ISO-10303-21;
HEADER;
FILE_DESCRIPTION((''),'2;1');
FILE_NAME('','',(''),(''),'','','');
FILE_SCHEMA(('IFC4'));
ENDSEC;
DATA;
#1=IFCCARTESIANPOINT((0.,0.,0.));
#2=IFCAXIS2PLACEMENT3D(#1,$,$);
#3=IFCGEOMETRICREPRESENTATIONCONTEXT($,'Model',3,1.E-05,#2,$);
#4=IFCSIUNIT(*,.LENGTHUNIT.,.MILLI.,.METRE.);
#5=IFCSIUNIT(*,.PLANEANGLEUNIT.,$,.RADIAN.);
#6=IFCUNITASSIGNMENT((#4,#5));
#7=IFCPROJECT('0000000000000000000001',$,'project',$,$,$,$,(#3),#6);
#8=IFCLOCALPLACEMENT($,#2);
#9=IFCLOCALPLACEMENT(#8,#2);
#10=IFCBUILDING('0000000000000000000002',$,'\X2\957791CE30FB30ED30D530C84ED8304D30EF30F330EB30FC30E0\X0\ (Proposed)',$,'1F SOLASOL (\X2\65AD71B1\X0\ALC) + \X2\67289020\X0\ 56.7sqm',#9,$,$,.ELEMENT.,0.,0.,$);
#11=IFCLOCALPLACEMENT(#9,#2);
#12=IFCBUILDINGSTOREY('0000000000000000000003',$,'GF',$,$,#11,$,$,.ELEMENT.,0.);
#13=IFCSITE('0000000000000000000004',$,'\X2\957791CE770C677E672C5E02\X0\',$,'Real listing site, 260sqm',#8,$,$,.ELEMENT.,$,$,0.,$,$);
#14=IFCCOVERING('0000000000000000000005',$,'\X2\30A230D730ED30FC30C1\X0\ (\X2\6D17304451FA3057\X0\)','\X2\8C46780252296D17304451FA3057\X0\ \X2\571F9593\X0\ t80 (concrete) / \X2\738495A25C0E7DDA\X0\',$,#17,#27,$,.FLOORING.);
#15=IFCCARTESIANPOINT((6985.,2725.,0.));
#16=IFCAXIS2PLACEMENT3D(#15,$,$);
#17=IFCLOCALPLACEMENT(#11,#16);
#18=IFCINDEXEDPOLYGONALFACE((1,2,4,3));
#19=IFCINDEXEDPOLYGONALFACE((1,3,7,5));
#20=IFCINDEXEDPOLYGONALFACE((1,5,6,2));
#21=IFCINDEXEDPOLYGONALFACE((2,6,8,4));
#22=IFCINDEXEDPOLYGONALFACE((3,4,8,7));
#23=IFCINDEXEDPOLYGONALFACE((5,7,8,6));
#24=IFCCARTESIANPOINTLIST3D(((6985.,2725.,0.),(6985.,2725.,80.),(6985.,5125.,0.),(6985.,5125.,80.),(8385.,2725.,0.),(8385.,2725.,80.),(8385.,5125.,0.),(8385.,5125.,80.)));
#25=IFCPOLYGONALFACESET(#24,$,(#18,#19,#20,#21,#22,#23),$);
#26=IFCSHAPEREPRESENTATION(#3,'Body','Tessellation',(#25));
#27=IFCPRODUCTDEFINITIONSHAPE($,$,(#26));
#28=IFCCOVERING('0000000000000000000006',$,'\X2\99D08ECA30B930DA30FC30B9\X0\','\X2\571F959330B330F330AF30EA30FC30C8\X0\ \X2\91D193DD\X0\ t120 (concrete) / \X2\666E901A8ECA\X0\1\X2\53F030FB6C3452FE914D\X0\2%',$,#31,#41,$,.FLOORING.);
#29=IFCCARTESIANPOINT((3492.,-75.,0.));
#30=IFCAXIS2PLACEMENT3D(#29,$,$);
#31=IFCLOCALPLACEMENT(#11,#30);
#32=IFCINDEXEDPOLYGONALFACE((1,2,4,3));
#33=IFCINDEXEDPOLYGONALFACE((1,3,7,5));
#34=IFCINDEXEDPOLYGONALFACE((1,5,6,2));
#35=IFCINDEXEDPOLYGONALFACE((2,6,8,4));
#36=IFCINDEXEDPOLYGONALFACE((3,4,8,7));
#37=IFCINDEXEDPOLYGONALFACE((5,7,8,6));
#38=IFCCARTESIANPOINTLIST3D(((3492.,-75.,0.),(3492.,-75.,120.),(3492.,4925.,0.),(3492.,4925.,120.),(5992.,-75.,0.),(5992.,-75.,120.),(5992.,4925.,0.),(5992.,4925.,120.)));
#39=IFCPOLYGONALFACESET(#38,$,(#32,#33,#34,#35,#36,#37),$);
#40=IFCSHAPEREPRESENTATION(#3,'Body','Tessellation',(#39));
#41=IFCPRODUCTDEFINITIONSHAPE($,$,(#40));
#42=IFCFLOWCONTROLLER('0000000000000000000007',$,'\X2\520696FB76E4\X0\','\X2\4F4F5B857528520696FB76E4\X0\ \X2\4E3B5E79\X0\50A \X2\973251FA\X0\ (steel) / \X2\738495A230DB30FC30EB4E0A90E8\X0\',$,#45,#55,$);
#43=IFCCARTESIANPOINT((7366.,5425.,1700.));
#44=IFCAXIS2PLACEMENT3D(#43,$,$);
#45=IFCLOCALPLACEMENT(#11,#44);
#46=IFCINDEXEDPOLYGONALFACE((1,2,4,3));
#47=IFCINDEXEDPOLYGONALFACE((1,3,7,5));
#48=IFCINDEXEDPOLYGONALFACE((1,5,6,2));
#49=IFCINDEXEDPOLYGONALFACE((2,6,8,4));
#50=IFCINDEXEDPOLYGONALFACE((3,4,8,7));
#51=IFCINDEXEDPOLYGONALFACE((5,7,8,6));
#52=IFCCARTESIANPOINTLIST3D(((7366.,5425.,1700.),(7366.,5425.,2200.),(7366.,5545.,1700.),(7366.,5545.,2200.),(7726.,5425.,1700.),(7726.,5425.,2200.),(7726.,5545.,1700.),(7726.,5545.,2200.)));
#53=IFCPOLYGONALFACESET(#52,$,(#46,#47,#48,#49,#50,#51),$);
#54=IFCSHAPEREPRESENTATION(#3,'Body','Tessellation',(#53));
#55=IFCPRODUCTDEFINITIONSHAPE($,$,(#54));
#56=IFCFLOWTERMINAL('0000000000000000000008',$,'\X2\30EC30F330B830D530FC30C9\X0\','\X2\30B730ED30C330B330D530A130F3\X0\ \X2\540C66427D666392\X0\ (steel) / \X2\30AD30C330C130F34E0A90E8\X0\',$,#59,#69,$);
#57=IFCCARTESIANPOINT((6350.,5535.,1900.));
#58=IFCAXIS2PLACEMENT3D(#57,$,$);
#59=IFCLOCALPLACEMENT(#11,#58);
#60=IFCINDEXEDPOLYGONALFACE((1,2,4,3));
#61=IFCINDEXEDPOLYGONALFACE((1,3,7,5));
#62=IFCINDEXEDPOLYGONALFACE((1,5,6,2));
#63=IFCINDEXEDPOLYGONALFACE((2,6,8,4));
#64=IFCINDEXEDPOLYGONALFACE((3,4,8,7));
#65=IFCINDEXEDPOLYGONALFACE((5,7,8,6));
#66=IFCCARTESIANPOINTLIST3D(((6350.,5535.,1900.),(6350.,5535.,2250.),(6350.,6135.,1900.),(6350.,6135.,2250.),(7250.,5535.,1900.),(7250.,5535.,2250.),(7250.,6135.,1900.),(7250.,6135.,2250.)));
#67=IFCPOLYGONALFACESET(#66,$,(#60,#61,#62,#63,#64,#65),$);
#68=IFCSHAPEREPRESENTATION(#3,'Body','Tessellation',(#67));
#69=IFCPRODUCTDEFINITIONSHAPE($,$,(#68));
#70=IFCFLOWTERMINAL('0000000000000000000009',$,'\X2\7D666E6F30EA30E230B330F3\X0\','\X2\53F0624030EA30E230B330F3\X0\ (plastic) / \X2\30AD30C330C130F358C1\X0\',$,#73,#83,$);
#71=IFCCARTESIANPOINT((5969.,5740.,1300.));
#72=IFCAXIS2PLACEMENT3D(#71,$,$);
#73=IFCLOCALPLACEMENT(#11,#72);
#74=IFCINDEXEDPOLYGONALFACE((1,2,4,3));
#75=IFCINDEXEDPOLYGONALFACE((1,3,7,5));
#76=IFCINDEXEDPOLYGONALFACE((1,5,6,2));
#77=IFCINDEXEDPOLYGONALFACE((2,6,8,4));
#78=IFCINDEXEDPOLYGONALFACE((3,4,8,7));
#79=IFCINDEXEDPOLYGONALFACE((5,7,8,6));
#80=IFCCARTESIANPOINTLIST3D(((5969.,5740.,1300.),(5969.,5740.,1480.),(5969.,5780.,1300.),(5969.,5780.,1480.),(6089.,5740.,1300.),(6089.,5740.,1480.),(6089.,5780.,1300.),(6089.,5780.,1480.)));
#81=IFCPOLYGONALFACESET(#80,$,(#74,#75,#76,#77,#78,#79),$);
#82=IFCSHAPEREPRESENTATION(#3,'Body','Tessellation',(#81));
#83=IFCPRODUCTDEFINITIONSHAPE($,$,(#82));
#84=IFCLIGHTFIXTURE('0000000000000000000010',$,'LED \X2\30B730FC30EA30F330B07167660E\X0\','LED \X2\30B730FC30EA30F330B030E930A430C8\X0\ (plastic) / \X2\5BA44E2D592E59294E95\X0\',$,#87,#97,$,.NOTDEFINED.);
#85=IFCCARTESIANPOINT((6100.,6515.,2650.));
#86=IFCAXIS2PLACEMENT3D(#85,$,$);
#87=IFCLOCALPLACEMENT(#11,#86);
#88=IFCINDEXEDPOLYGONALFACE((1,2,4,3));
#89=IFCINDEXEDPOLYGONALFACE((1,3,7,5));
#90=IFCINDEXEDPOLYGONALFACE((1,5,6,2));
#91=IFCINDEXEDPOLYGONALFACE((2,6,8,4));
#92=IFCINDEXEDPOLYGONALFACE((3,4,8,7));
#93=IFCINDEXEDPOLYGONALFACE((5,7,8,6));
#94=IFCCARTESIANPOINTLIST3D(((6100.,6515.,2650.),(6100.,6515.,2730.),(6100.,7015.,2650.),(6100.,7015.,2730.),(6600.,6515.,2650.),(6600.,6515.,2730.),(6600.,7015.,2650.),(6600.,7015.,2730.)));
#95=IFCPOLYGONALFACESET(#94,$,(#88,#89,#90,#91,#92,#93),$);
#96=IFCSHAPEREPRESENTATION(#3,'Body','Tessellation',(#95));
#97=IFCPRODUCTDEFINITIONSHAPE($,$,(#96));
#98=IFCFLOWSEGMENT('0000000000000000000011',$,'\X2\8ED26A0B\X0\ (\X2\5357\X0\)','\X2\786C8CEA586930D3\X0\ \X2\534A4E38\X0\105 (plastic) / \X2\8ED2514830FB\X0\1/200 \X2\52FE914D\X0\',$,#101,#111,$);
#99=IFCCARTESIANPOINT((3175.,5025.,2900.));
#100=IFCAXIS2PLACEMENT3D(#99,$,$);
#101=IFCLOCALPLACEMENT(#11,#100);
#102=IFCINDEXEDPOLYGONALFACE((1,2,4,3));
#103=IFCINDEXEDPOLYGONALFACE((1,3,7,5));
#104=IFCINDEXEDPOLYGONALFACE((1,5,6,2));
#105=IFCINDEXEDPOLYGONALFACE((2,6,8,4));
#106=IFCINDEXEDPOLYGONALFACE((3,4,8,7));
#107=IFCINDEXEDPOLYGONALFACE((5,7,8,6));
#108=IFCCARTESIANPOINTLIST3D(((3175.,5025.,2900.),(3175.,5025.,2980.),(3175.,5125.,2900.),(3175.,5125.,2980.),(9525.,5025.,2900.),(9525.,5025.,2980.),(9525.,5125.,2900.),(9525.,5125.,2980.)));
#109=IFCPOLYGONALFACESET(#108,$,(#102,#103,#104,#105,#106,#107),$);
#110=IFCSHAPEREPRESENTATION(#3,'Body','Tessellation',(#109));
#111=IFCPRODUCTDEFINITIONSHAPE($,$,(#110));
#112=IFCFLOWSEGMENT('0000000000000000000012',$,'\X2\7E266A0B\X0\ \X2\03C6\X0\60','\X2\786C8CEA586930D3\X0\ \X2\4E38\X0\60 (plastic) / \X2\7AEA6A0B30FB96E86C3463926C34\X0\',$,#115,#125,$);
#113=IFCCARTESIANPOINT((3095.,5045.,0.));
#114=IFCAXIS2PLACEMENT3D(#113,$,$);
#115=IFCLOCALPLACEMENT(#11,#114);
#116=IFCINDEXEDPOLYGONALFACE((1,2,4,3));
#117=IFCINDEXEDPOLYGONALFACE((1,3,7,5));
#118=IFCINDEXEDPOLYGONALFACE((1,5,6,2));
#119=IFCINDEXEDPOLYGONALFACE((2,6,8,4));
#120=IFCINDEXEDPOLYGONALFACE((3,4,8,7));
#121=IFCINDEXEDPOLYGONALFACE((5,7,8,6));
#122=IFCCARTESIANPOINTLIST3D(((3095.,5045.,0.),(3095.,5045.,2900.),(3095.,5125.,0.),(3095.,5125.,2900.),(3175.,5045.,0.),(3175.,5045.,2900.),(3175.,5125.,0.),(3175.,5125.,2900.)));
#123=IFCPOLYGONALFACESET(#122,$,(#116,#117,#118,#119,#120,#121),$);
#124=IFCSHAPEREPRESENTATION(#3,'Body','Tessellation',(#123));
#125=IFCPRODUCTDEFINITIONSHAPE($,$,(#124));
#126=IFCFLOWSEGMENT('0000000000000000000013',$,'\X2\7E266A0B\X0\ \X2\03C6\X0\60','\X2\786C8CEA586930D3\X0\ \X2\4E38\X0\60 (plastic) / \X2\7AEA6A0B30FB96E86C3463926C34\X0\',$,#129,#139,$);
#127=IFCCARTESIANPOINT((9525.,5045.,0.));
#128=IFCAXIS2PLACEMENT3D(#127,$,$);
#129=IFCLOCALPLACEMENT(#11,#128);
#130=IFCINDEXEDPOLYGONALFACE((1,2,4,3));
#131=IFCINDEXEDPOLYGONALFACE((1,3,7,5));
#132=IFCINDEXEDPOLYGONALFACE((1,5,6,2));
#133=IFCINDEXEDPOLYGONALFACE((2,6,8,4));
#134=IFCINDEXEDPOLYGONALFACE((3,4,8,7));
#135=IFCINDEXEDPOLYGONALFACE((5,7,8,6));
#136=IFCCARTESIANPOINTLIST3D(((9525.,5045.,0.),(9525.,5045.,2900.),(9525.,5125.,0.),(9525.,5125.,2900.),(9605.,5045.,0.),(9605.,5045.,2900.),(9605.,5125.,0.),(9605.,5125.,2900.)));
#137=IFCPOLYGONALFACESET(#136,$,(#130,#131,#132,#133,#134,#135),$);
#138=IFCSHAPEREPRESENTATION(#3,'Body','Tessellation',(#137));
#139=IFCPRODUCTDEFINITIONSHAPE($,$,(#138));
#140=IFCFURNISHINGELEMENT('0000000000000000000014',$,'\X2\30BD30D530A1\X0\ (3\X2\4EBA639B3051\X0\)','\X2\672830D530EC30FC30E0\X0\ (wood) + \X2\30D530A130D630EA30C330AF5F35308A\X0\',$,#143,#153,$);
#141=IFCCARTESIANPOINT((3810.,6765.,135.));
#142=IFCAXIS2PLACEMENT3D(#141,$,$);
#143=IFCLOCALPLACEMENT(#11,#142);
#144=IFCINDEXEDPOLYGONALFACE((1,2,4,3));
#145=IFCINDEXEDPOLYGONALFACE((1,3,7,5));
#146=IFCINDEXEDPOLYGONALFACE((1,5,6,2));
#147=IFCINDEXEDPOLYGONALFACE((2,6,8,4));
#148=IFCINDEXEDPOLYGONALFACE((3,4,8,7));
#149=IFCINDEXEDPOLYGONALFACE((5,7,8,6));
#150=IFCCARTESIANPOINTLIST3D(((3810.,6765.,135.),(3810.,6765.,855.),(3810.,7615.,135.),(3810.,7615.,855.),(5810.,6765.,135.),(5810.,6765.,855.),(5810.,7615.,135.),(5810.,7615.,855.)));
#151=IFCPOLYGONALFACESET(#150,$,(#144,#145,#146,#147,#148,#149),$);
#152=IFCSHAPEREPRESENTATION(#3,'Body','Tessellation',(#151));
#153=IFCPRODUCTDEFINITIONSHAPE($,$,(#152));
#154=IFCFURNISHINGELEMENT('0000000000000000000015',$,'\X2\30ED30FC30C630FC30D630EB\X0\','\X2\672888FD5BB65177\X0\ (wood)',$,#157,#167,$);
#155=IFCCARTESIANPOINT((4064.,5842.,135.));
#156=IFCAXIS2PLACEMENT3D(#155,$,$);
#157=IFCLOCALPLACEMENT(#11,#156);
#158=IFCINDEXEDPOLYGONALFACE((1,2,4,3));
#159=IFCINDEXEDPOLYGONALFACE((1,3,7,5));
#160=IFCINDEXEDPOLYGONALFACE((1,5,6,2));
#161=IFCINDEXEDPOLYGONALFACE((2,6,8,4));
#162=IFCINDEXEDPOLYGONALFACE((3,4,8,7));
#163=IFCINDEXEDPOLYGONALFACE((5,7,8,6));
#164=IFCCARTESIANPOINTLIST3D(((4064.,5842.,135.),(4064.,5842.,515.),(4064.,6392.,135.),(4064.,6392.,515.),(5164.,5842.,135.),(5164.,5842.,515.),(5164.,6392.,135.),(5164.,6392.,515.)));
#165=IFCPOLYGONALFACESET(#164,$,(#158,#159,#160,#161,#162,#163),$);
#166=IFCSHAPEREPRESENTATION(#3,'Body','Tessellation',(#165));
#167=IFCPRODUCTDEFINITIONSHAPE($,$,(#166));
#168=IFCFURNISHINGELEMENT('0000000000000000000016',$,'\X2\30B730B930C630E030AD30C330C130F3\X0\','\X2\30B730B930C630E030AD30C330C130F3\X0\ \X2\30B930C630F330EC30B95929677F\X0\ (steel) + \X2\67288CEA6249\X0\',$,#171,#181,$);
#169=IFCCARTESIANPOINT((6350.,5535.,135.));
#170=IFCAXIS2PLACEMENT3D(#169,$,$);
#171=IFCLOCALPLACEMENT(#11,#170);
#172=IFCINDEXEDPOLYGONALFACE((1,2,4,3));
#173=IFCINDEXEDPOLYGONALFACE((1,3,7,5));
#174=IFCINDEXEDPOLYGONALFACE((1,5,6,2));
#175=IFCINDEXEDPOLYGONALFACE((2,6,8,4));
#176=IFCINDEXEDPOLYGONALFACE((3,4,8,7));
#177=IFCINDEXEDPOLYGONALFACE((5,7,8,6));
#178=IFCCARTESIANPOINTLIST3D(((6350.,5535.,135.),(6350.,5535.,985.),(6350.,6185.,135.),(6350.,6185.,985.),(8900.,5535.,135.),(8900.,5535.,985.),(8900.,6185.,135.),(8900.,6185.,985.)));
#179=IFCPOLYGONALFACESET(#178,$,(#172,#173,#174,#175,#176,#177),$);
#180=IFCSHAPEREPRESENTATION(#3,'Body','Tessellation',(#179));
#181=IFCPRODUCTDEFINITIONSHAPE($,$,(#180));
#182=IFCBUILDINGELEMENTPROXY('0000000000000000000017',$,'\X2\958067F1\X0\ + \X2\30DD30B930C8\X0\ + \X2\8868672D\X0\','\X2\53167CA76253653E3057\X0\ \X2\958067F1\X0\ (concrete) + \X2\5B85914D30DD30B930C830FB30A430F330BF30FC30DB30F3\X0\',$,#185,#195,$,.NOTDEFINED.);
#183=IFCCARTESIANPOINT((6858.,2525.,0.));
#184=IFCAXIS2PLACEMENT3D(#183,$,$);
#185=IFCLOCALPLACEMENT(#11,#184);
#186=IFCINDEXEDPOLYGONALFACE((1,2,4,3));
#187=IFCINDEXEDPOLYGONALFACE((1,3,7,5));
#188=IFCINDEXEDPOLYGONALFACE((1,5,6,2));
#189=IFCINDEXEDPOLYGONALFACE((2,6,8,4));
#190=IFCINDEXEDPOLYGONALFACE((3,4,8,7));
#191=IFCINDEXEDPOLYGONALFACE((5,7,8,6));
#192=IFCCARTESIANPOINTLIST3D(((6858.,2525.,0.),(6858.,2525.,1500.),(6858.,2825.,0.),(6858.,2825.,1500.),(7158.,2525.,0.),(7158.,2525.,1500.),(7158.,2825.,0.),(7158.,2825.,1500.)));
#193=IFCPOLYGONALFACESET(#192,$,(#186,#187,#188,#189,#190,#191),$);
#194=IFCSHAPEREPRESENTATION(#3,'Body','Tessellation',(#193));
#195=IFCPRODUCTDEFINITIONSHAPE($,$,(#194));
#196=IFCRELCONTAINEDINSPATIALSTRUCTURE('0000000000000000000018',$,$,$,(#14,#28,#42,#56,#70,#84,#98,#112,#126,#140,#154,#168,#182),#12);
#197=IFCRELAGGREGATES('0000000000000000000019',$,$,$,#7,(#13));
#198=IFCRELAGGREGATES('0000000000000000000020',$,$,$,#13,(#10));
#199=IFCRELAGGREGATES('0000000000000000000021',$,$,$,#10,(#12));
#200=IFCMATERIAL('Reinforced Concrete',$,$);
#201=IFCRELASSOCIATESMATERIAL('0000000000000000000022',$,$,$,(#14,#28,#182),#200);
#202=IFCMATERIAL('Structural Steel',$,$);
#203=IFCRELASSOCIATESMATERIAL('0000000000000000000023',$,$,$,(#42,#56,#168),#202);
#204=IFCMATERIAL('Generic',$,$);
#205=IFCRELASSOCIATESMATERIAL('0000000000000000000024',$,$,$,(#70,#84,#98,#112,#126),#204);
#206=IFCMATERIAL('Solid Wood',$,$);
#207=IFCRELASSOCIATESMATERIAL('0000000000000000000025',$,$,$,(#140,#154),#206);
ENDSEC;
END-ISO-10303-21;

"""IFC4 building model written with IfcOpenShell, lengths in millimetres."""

from ifc_helpers import new_model, si_unit, frame, frame_2d, origin, place, context, project, spatial, rectangle, extrude, material, element, save


model = new_model("IFC4")

# Units and contexts
model_context = context("Model", 3, precision=1e-05, world=origin())
ifc_project = project(units=[si_unit("LENGTHUNIT", "METRE", prefix="MILLI"), si_unit("PLANEANGLEUNIT", "RADIAN")], contexts=[model_context])

# Site, building, storey
site_placement = place(None, origin())
site = spatial("IfcSite", under=ifc_project, at=site_placement, Name="長野県松本市", ObjectType="Real listing site, 260sqm", CompositionType="ELEMENT", RefElevation=0.0)
building_placement = place(site_placement, origin())
building = spatial("IfcBuilding", under=site, at=building_placement, Name="長野・ロフト付きワンルーム (Proposed)", ObjectType="1F SOLASOL (断熱ALC) + 木造 56.7sqm", CompositionType="ELEMENT", ElevationOfRefHeight=0.0, ElevationOfTerrain=0.0)
storey_placement = place(building_placement, origin())
storey = spatial("IfcBuildingStorey", under=building, at=storey_placement, Name="GF", CompositionType="ELEMENT", Elevation=0.0)

# Shared definitions
ifc_material_1 = material(Name="Solid Wood")

# Shared definitions
ifc_material_2 = material(Name="Reinforced Concrete")

# Shared definitions
ifc_material_3 = material(Name="Structural Steel")

# Coverings
ifc_material_4 = material(Name="Generic")
covering_1_placement = place(storey_placement, frame((6985.0, 2725.0, 0.0)))
element("IfcCovering", 1, at=covering_1_placement, inside=storey, material=ifc_material_2, Name="アプローチ (洗い出し)", Description="豆砂利洗い出し 土間 t80 (concrete) / 玄関導線", PredefinedType="FLOORING", context=model_context, shape_type="SweptSolid", body=[
    extrude(rectangle(XDim=1400.0, YDim=2400.0, at=frame_2d((700.0, 1200.0))), frame((6985.0, 2725.0, 0.0)), (0.0, 0.0, 1.0), 80.0),
])
covering_2_placement = place(storey_placement, frame((3492.0, -75.0, 0.0)))
element("IfcCovering", 2, at=covering_2_placement, inside=storey, material=ifc_material_2, Name="駐車スペース", Description="土間コンクリート 金鏝 t120 (concrete) / 普通車1台・水勾配2%", PredefinedType="FLOORING", context=model_context, shape_type="SweptSolid", body=[
    extrude(rectangle(XDim=2500.0, YDim=5000.0, at=frame_2d((1250.0, 2500.0))), frame((3492.0, -75.0, 0.0)), (0.0, 0.0, 1.0), 120.0),
])

# Flow controller
flow_controller_placement = place(storey_placement, frame((7366.0, 5425.0, 1700.0)))
element("IfcFlowController", 3, at=flow_controller_placement, inside=storey, material=ifc_material_3, Name="分電盤", Description="住宅用分電盤 主幹50A 露出 (steel) / 玄関ホール上部", context=model_context, shape_type="SweptSolid", body=[
    extrude(rectangle(XDim=360.0, YDim=120.0, at=frame_2d((180.0, 60.0))), frame((7366.0, 5425.0, 1700.0)), (0.0, 0.0, 1.0), 500.0),
])

# Flow terminals
flow_terminal_1_placement = place(storey_placement, frame((6350.0, 5535.0, 1900.0)))
element("IfcFlowTerminal", 4, at=flow_terminal_1_placement, inside=storey, material=ifc_material_3, Name="レンジフード", Description="シロッコファン 同時給排 (steel) / キッチン上部", context=model_context, shape_type="SweptSolid", body=[
    extrude(rectangle(XDim=900.0, YDim=600.0, at=frame_2d((450.0, 300.0))), frame((6350.0, 5535.0, 1900.0)), (0.0, 0.0, 1.0), 350.0),
])
flow_terminal_2_placement = place(storey_placement, frame((5969.0, 5740.0, 1300.0)))
element("IfcFlowTerminal", 5, at=flow_terminal_2_placement, inside=storey, material=ifc_material_4, Name="給湯リモコン", Description="台所リモコン (plastic) / キッチン壁", context=model_context, shape_type="SweptSolid", body=[
    extrude(rectangle(XDim=120.0, YDim=40.0, at=frame_2d((60.0, 20.0))), frame((5969.0, 5740.0, 1300.0)), (0.0, 0.0, 1.0), 180.0),
])

# Light fixture
light_fixture_placement = place(storey_placement, frame((6100.0, 6515.0, 2650.0)))
element("IfcLightFixture", 6, at=light_fixture_placement, inside=storey, material=ifc_material_4, Name="LED シーリング照明", Description="LED シーリングライト (plastic) / 室中央天井", PredefinedType="NOTDEFINED", context=model_context, shape_type="SweptSolid", body=[
    extrude(rectangle(XDim=500.0, YDim=500.0, at=frame_2d((250.0, 250.0))), frame((6100.0, 6515.0, 2650.0)), (0.0, 0.0, 1.0), 80.0),
])

# Flow segments
flow_segment_1_placement = place(storey_placement, frame((3175.0, 5025.0, 2900.0)))
element("IfcFlowSegment", 7, at=flow_segment_1_placement, inside=storey, material=ifc_material_4, Name="軒樋 (南)", Description="硬質塩ビ 半丸105 (plastic) / 軒先・1/200 勾配", context=model_context, shape_type="SweptSolid", body=[
    extrude(rectangle(XDim=6350.0, YDim=100.0, at=frame_2d((3175.0, 50.0))), frame((3175.0, 5025.0, 2900.0)), (0.0, 0.0, 1.0), 80.0),
])
flow_segment_2_placement = place(storey_placement, frame((3095.0, 5045.0, 0.0)))
element("IfcFlowSegment", 8, at=flow_segment_2_placement, inside=storey, material=ifc_material_4, Name="縦樋 φ60", Description="硬質塩ビ 丸60 (plastic) / 竪樋・雨水排水", context=model_context, shape_type="SweptSolid", body=[
    extrude(rectangle(XDim=80.0, YDim=80.0, at=frame_2d((40.0, 40.0))), frame((3095.0, 5045.0, 0.0)), (0.0, 0.0, 1.0), 2900.0),
])
flow_segment_3_placement = place(storey_placement, frame((9525.0, 5045.0, 0.0)))
element("IfcFlowSegment", 9, at=flow_segment_3_placement, inside=storey, material=ifc_material_4, Name="縦樋 φ60", Description="硬質塩ビ 丸60 (plastic) / 竪樋・雨水排水", context=model_context, shape_type="SweptSolid", body=[
    extrude(rectangle(XDim=80.0, YDim=80.0, at=frame_2d((40.0, 40.0))), frame((9525.0, 5045.0, 0.0)), (0.0, 0.0, 1.0), 2900.0),
])

# Furnishing elements
furnishing_1_placement = place(storey_placement, frame((3810.0, 6765.0, 135.0)))
element("IfcFurnishingElement", 10, at=furnishing_1_placement, inside=storey, material=ifc_material_1, Name="ソファ (3人掛け)", Description="木フレーム (wood) + ファブリック張り", context=model_context, shape_type="SweptSolid", body=[
    extrude(rectangle(XDim=2000.0, YDim=850.0, at=frame_2d((1000.0, 425.0))), frame((3810.0, 6765.0, 135.0)), (0.0, 0.0, 1.0), 720.0),
])
furnishing_2_placement = place(storey_placement, frame((4064.0, 5842.0, 135.0)))
element("IfcFurnishingElement", 11, at=furnishing_2_placement, inside=storey, material=ifc_material_1, Name="ローテーブル", Description="木製家具 (wood)", context=model_context, shape_type="SweptSolid", body=[
    extrude(rectangle(XDim=1100.0, YDim=550.0, at=frame_2d((550.0, 275.0))), frame((4064.0, 5842.0, 135.0)), (0.0, 0.0, 1.0), 380.0),
])
furnishing_3_placement = place(storey_placement, frame((6350.0, 5535.0, 135.0)))
element("IfcFurnishingElement", 12, at=furnishing_3_placement, inside=storey, material=ifc_material_3, Name="システムキッチン", Description="システムキッチン ステンレス天板 (steel) + 木質扉", context=model_context, shape_type="SweptSolid", body=[
    extrude(rectangle(XDim=2550.0, YDim=650.0, at=frame_2d((1275.0, 325.0))), frame((6350.0, 5535.0, 135.0)), (0.0, 0.0, 1.0), 850.0),
])

# Building element proxy
proxy_placement = place(storey_placement, frame((6858.0, 2525.0, 0.0)))
element("IfcBuildingElementProxy", 13, at=proxy_placement, inside=storey, material=ifc_material_2, Name="門柱 + ポスト + 表札", Description="化粧打放し 門柱 (concrete) + 宅配ポスト・インターホン", PredefinedType="NOTDEFINED", context=model_context, shape_type="SweptSolid", body=[
    extrude(rectangle(XDim=300.0, YDim=300.0, at=frame_2d((150.0, 150.0))), frame((6858.0, 2525.0, 0.0)), (0.0, 0.0, 1.0), 1500.0),
])

save(model, "model.ifc")
